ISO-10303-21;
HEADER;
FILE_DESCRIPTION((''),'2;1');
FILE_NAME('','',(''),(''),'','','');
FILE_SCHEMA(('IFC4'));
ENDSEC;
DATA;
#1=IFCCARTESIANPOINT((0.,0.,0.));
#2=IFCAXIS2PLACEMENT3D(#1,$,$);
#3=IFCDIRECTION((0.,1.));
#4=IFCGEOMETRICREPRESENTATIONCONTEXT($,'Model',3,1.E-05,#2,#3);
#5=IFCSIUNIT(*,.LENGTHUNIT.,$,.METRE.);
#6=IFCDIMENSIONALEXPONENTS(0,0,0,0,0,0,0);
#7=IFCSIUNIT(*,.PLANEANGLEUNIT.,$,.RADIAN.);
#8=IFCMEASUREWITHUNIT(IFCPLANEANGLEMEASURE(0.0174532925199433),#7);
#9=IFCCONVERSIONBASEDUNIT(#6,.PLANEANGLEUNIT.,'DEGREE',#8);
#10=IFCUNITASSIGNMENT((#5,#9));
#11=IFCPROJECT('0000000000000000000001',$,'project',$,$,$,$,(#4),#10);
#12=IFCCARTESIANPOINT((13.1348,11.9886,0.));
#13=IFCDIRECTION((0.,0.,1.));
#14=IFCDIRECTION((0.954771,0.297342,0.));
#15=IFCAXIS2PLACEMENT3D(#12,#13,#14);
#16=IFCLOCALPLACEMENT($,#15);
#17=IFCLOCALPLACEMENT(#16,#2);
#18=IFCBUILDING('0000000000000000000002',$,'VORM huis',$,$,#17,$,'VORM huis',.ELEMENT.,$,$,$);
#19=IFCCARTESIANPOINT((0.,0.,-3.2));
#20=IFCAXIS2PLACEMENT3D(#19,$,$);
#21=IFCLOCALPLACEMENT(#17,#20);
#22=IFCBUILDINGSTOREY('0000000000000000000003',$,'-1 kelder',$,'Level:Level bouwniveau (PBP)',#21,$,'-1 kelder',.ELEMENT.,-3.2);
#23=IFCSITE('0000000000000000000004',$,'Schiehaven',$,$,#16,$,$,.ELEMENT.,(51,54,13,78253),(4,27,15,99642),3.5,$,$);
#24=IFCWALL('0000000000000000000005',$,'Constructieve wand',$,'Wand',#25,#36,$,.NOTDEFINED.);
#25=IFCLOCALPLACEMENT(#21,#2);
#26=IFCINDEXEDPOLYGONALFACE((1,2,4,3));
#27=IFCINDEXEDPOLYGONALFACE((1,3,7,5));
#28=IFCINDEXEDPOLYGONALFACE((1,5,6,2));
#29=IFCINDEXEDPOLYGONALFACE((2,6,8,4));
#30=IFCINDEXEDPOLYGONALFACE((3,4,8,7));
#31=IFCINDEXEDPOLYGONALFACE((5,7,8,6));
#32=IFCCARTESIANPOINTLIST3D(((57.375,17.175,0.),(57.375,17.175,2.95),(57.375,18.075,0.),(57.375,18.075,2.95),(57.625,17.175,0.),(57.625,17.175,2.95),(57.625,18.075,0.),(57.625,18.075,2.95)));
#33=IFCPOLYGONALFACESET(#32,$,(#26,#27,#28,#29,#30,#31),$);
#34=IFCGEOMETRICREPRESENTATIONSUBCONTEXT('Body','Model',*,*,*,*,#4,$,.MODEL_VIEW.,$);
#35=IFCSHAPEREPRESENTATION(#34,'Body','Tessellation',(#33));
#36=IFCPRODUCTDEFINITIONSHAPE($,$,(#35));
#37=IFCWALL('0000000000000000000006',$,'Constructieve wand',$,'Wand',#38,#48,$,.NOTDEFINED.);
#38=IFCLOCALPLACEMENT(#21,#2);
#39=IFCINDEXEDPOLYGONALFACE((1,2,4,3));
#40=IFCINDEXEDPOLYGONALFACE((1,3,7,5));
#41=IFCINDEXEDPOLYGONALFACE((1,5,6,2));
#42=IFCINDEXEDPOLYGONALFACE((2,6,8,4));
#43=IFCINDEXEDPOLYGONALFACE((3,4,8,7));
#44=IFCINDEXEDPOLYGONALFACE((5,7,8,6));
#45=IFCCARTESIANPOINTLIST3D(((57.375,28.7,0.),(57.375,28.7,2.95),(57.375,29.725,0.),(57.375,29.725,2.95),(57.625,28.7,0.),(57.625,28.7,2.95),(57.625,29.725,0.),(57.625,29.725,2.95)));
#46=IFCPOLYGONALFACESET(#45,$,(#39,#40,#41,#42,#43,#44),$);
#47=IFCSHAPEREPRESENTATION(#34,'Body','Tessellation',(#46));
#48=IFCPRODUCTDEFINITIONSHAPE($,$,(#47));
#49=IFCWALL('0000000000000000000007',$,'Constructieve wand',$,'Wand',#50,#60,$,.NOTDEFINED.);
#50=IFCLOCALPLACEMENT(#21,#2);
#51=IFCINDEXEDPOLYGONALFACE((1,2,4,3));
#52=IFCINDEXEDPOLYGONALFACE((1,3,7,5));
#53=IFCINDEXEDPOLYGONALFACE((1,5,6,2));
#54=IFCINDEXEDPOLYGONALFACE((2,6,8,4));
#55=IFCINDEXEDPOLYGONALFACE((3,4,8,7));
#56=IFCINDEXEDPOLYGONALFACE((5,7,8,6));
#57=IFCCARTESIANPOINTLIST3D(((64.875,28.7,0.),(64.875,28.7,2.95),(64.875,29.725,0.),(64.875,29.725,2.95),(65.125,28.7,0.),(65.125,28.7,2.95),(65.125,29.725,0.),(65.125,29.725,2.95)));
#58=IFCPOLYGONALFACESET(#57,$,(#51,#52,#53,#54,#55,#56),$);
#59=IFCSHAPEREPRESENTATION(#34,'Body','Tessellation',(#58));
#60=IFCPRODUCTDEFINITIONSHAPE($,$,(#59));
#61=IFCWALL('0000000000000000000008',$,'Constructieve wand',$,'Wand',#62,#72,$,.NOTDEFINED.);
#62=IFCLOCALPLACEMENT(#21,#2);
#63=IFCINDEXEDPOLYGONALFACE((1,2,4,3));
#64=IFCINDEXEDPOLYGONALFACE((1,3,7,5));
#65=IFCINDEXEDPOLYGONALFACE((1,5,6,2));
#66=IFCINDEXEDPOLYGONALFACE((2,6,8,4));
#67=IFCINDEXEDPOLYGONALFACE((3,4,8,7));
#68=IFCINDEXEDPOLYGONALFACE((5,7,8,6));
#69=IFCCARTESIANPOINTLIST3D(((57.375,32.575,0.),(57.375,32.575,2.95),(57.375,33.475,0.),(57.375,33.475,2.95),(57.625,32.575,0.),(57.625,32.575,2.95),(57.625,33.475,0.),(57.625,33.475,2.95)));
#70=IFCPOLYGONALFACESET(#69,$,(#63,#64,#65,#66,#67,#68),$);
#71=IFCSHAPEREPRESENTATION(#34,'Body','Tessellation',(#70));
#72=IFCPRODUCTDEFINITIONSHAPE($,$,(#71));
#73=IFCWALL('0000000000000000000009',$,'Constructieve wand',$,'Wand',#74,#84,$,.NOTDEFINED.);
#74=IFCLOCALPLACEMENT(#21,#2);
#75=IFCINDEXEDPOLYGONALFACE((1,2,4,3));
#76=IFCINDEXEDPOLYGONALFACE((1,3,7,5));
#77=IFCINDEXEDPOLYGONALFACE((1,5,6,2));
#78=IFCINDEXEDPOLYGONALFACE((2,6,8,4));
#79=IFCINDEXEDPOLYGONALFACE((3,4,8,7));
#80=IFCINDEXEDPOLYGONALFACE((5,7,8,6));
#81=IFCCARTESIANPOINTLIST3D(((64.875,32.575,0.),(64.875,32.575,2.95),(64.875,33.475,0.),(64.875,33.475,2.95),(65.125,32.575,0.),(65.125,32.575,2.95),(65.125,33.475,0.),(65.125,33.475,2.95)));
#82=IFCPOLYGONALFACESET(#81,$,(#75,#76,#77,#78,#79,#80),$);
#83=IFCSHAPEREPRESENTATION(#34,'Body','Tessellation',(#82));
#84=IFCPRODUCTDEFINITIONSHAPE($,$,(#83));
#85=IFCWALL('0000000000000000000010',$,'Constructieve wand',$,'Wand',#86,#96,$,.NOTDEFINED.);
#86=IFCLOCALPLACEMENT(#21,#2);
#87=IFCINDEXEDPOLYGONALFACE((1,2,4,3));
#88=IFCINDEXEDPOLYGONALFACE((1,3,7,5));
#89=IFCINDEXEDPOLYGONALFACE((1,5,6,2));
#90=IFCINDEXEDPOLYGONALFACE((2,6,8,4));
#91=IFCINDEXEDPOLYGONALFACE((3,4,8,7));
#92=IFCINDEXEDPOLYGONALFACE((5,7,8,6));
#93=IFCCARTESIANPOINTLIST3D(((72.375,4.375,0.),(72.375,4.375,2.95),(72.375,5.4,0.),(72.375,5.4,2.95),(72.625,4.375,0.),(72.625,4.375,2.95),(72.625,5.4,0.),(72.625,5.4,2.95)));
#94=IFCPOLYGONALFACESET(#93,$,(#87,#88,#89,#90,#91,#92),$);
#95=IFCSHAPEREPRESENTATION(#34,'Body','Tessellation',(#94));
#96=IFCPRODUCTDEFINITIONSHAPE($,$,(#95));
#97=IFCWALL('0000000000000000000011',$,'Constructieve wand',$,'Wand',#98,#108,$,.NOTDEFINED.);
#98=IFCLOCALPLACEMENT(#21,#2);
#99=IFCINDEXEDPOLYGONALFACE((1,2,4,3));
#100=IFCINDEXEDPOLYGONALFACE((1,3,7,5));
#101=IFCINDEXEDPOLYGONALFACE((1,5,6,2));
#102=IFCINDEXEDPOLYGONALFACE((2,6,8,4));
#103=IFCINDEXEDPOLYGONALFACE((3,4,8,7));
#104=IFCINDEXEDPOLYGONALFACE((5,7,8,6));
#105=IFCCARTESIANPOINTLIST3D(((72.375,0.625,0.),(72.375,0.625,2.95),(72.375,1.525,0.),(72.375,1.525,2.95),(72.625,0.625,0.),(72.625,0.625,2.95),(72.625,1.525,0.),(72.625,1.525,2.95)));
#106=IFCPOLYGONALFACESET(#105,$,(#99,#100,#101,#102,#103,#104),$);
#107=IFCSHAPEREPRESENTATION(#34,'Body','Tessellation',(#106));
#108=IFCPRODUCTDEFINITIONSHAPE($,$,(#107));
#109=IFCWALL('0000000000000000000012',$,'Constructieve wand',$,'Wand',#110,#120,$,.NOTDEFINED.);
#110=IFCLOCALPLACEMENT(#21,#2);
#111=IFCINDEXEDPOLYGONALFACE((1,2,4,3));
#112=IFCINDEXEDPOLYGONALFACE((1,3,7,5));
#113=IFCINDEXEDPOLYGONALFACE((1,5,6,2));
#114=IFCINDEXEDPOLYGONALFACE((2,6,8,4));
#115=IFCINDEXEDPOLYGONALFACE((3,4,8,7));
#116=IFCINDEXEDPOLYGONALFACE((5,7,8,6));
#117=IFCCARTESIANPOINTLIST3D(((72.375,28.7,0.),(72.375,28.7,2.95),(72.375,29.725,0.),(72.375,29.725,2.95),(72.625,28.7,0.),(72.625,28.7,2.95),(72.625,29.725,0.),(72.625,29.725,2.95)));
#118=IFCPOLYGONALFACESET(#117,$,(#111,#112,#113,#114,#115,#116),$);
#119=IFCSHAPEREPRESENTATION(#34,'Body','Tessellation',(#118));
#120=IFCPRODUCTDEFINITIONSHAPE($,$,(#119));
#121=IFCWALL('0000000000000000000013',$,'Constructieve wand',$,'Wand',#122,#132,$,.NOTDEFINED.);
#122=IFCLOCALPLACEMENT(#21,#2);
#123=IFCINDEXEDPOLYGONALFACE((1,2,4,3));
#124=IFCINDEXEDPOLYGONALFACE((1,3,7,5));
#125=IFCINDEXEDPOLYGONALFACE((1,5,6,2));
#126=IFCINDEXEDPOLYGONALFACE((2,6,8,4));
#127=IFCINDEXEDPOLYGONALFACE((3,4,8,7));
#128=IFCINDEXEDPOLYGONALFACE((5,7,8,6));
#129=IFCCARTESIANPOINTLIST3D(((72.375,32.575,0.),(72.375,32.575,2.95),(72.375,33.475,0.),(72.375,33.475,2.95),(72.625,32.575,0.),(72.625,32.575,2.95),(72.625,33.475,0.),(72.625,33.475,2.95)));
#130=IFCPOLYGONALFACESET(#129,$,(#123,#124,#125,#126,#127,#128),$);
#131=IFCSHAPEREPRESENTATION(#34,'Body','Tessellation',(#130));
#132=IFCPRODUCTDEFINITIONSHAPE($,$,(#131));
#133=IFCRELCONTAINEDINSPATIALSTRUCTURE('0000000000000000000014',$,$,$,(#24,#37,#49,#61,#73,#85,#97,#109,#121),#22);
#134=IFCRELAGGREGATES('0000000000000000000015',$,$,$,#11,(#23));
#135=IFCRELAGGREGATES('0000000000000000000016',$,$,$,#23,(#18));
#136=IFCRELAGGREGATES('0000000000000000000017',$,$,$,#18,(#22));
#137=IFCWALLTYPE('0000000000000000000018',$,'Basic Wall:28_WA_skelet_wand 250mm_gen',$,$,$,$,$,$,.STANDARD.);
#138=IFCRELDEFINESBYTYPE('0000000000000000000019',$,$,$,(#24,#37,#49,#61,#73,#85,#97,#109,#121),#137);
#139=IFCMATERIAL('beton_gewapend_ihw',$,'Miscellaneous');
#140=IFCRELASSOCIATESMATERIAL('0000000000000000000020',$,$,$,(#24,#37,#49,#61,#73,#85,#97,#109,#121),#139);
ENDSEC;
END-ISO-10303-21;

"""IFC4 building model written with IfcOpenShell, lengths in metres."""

from ifc_helpers import new_model, entity, si_unit, converted_unit, direction, frame, origin, place, context, subcontext, project, spatial, indexed_curve, outline, extrude, material, type_object, element, save


model = new_model("IFC4")

# Units and contexts
model_context = context("Model", 3, precision=1e-05, world=origin(), true_north=direction((0.0, 1.0)))
body_context = subcontext(model_context, "Body", "Model", "MODEL_VIEW")
ifc_project = project(units=[si_unit("LENGTHUNIT", "METRE"), converted_unit("PLANEANGLEUNIT", "DEGREE", entity("IfcPlaneAngleMeasure", 0.0174532925199433), si_unit("PLANEANGLEUNIT", "RADIAN"), dimensions=[0, 0, 0, 0, 0, 0, 0])], contexts=[model_context])

# Site, building, storey
site_placement = place(None, frame((13.1348, 11.9886, 0.0), z_axis=(0.0, 0.0, 1.0), x_axis=(0.954771, 0.297342, 0.0)))
site = spatial("IfcSite", under=ifc_project, at=site_placement, Name="Schiehaven", CompositionType="ELEMENT", RefLatitude=(51, 54, 13, 78253), RefLongitude=(4, 27, 15, 99642), RefElevation=3.5)
building_placement = place(site_placement, origin())
building = spatial("IfcBuilding", under=site, at=building_placement, Name="VORM huis", LongName="VORM huis", CompositionType="ELEMENT")
storey_placement = place(building_placement, frame((0.0, 0.0, -3.2)))
storey = spatial("IfcBuildingStorey", under=building, at=storey_placement, Name="-1 kelder", ObjectType="Level:Level bouwniveau (PBP)", LongName="-1 kelder", CompositionType="ELEMENT", Elevation=-3.2)

# Walls
ifc_material = material(Name="beton_gewapend_ihw", Category="Miscellaneous")
wall_type_1 = type_object("IfcWallType", Name="Basic Wall:28_WA_skelet_wand 250mm_gen", PredefinedType="STANDARD")
wall_1_placement = place(storey_placement, frame((57.5, 18.075, 0.0), z_axis=(0.0, 0.0, 1.0), x_axis=(0.0, -1.0, 0.0)))
element("IfcWall", 1, at=wall_1_placement, inside=storey, type_object=wall_type_1, material=ifc_material, Name="Constructieve wand", ObjectType="Wand", PredefinedType="NOTDEFINED", context=body_context, shape_type="SweptSolid", body=[
    extrude(outline(indexed_curve([(0.9, 0.125), (0.0, 0.125), (0.0, -0.125), (0.9, -0.125), (0.9, 0.125)], self_intersect=False)), origin(), (0.0, 0.0, 1.0), 2.95),
])
wall_2_placement = place(storey_placement, frame((57.5, 29.725, 0.0), z_axis=(0.0, 0.0, 1.0), x_axis=(0.0, -1.0, 0.0)))
element("IfcWall", 2, at=wall_2_placement, inside=storey, type_object=wall_type_1, material=ifc_material, Name="Constructieve wand", ObjectType="Wand", PredefinedType="NOTDEFINED", context=body_context, shape_type="SweptSolid", body=[
    extrude(outline(indexed_curve([(1.025, 0.125), (0.0, 0.125), (0.0, -0.125), (1.025, -0.125), (1.025, 0.125)], self_intersect=False)), origin(), (0.0, 0.0, 1.0), 2.95),
])
wall_3_placement = place(storey_placement, frame((65.0, 29.725, 0.0), z_axis=(0.0, 0.0, 1.0), x_axis=(0.0, -1.0, 0.0)))
element("IfcWall", 3, at=wall_3_placement, inside=storey, type_object=wall_type_1, material=ifc_material, Name="Constructieve wand", ObjectType="Wand", PredefinedType="NOTDEFINED", context=body_context, shape_type="SweptSolid", body=[
    extrude(outline(indexed_curve([(1.025, 0.125), (0.0, 0.125), (0.0, -0.125), (1.025, -0.125), (1.025, 0.125)], self_intersect=False)), origin(), (0.0, 0.0, 1.0), 2.95),
])
wall_4_placement = place(storey_placement, frame((57.5, 32.575, 0.0), z_axis=(0.0, 0.0, 1.0), x_axis=(0.0, 1.0, 0.0)))
element("IfcWall", 4, at=wall_4_placement, inside=storey, type_object=wall_type_1, material=ifc_material, Name="Constructieve wand", ObjectType="Wand", PredefinedType="NOTDEFINED", context=body_context, shape_type="SweptSolid", body=[
    extrude(outline(indexed_curve([(0.9, 0.125), (0.0, 0.125), (0.0, -0.125), (0.9, -0.125), (0.9, 0.125)], self_intersect=False)), origin(), (0.0, 0.0, 1.0), 2.95),
])
wall_5_placement = place(storey_placement, frame((65.0, 32.575, 0.0), z_axis=(0.0, 0.0, 1.0), x_axis=(0.0, 1.0, 0.0)))
element("IfcWall", 5, at=wall_5_placement, inside=storey, type_object=wall_type_1, material=ifc_material, Name="Constructieve wand", ObjectType="Wand", PredefinedType="NOTDEFINED", context=body_context, shape_type="SweptSolid", body=[
    extrude(outline(indexed_curve([(0.9, 0.125), (0.0, 0.125), (0.0, -0.125), (0.9, -0.125), (0.9, 0.125)], self_intersect=False)), origin(), (0.0, 0.0, 1.0), 2.95),
])
wall_6_placement = place(storey_placement, frame((72.5, 4.375, 0.0), z_axis=(0.0, 0.0, 1.0), x_axis=(0.0, 1.0, 0.0)))
element("IfcWall", 6, at=wall_6_placement, inside=storey, type_object=wall_type_1, material=ifc_material, Name="Constructieve wand", ObjectType="Wand", PredefinedType="NOTDEFINED", context=body_context, shape_type="SweptSolid", body=[
    extrude(outline(indexed_curve([(1.025, 0.125), (0.0, 0.125), (0.0, -0.125), (1.025, -0.125), (1.025, 0.125)], self_intersect=False)), origin(), (0.0, 0.0, 1.0), 2.95),
])
wall_7_placement = place(storey_placement, frame((72.5, 1.525, 0.0), z_axis=(0.0, 0.0, 1.0), x_axis=(0.0, -1.0, 0.0)))
element("IfcWall", 7, at=wall_7_placement, inside=storey, type_object=wall_type_1, material=ifc_material, Name="Constructieve wand", ObjectType="Wand", PredefinedType="NOTDEFINED", context=body_context, shape_type="SweptSolid", body=[
    extrude(outline(indexed_curve([(0.9, 0.125), (0.0, 0.125), (0.0, -0.125), (0.9, -0.125), (0.9, 0.125)], self_intersect=False)), origin(), (0.0, 0.0, 1.0), 2.95),
])
wall_8_placement = place(storey_placement, frame((72.5, 29.725, 0.0), z_axis=(0.0, 0.0, 1.0), x_axis=(0.0, -1.0, 0.0)))
element("IfcWall", 8, at=wall_8_placement, inside=storey, type_object=wall_type_1, material=ifc_material, Name="Constructieve wand", ObjectType="Wand", PredefinedType="NOTDEFINED", context=body_context, shape_type="SweptSolid", body=[
    extrude(outline(indexed_curve([(1.025, 0.125), (0.0, 0.125), (0.0, -0.125), (1.025, -0.125), (1.025, 0.125)], self_intersect=False)), origin(), (0.0, 0.0, 1.0), 2.95),
])
wall_9_placement = place(storey_placement, frame((72.5, 32.575, 0.0), z_axis=(0.0, 0.0, 1.0), x_axis=(0.0, 1.0, 0.0)))
element("IfcWall", 9, at=wall_9_placement, inside=storey, type_object=wall_type_1, material=ifc_material, Name="Constructieve wand", ObjectType="Wand", PredefinedType="NOTDEFINED", context=body_context, shape_type="SweptSolid", body=[
    extrude(outline(indexed_curve([(0.9, 0.125), (0.0, 0.125), (0.0, -0.125), (0.9, -0.125), (0.9, 0.125)], self_intersect=False)), origin(), (0.0, 0.0, 1.0), 2.95),
])

save(model, "model.ifc")
